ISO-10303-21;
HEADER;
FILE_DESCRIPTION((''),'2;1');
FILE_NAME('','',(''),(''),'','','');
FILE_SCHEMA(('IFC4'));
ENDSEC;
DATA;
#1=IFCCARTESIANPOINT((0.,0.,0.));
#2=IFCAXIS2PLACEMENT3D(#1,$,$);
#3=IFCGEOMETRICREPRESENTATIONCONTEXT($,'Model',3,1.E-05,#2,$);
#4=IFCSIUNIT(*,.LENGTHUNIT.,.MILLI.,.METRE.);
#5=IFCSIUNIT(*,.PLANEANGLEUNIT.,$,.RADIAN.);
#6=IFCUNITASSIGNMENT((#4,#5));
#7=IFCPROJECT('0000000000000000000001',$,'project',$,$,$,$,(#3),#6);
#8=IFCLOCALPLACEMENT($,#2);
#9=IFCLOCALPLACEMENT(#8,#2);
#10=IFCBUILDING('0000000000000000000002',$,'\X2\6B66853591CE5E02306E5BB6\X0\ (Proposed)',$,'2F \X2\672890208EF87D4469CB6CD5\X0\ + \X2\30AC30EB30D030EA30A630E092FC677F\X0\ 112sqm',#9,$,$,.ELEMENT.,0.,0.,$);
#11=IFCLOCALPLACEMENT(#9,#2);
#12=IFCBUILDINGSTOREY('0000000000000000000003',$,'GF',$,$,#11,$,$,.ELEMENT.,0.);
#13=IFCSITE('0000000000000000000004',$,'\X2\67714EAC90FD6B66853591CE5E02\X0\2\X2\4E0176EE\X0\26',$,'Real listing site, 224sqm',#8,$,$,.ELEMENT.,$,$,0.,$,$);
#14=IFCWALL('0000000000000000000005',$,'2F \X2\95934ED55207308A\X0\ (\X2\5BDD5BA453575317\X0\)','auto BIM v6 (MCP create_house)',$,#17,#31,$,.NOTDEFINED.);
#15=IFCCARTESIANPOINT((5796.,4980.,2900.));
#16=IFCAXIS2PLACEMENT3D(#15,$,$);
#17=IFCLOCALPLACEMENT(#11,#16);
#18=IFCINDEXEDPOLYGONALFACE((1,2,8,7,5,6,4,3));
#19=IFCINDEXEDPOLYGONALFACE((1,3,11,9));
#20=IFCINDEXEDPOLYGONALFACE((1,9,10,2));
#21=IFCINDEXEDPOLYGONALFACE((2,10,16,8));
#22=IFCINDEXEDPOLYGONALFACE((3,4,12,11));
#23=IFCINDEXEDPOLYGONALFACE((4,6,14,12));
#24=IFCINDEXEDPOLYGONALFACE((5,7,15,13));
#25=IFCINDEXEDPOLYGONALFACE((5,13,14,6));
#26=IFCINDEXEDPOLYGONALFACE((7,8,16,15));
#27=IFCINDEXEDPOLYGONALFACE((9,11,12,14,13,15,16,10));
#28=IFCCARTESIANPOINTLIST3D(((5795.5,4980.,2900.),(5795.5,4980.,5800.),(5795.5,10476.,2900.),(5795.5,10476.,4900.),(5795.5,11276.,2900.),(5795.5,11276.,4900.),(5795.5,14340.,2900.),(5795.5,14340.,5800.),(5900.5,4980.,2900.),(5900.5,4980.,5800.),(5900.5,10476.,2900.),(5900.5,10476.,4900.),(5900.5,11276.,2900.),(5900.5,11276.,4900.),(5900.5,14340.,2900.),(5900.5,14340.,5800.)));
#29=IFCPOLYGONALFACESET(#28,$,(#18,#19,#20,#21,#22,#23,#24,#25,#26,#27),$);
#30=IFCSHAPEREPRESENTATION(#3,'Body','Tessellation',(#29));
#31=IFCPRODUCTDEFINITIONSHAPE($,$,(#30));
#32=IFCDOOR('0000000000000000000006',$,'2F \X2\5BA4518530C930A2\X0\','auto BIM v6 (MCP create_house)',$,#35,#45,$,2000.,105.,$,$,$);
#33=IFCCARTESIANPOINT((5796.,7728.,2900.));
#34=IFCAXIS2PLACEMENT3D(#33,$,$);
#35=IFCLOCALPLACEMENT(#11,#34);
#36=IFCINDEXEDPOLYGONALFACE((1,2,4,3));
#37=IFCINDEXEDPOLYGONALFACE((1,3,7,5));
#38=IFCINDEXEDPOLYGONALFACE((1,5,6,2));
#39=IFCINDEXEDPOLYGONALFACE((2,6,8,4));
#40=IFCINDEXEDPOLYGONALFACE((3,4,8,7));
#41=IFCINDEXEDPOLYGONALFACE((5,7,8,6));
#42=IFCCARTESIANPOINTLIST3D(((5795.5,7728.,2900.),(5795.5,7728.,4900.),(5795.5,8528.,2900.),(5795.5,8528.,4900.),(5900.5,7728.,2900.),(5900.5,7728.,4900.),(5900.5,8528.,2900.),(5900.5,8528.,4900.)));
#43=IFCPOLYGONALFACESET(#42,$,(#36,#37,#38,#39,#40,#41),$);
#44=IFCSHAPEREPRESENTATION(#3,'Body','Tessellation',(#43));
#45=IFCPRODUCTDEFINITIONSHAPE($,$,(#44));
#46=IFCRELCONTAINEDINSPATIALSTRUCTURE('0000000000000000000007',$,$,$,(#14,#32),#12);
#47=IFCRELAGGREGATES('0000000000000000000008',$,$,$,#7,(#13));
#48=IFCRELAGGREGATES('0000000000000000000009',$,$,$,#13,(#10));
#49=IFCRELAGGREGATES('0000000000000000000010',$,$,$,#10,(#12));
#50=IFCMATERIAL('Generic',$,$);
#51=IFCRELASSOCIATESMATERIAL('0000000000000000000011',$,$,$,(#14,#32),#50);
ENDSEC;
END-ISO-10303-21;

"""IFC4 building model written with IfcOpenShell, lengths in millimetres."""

from ifc_helpers import new_model, si_unit, frame, frame_2d, origin, place, context, project, spatial, rectangle, extrude, material, element, fill, save


model = new_model("IFC4")

# Units and contexts
model_context = context("Model", 3, precision=1e-05, world=origin())
ifc_project = project(units=[si_unit("LENGTHUNIT", "METRE", prefix="MILLI"), si_unit("PLANEANGLEUNIT", "RADIAN")], contexts=[model_context])

# Site, building, storey
site_placement = place(None, origin())
site = spatial("IfcSite", under=ifc_project, at=site_placement, Name="東京都武蔵野市2丁目26", ObjectType="Real listing site, 224sqm", CompositionType="ELEMENT", RefElevation=0.0)
building_placement = place(site_placement, origin())
building = spatial("IfcBuilding", under=site, at=building_placement, Name="武蔵野市の家 (Proposed)", ObjectType="2F 木造軸組構法 + ガルバリウム鋼板 112sqm", CompositionType="ELEMENT", ElevationOfRefHeight=0.0, ElevationOfTerrain=0.0)
storey_placement = place(building_placement, origin())
storey = spatial("IfcBuildingStorey", under=building, at=storey_placement, Name="GF", CompositionType="ELEMENT", Elevation=0.0)

# Shared definitions
ifc_material = material(Name="Generic")

# Wall, opening, door
wall_1_placement = place(storey_placement, frame((5796.0, 4980.0, 2900.0)))
wall_1 = element("IfcWall", 1, at=wall_1_placement, inside=storey, material=ifc_material, Name="2F 間仕切り (寝室南北)", Description="auto BIM v6 (MCP create_house)", PredefinedType="NOTDEFINED", context=model_context, shape_type="SweptSolid", body=[
    extrude(rectangle(XDim=105.0, YDim=9360.0, at=frame_2d((52.0, 4680.0))), frame((5796.0, 4980.0, 2900.0)), (0.0, 0.0, 1.0), 2900.0),
])
opening_1_placement = place(storey_placement, frame((5796.0, 7728.0, 2900.0)))
opening_1 = element("IfcOpeningElement", 2, at=opening_1_placement, cuts=wall_1, PredefinedType="NOTDEFINED", context=model_context, shape_type="SweptSolid", body=[
    extrude(rectangle(XDim=105.0, YDim=800.0, at=frame_2d((52.0, 400.0))), frame((5796.0, 7728.0, 2900.0)), (0.0, 0.0, 1.0), 2000.0),
])
door_placement = place(storey_placement, frame((5796.0, 7728.0, 2900.0)))
door = element("IfcDoor", 3, at=door_placement, inside=storey, material=ifc_material, Name="2F 室内ドア", Description="auto BIM v6 (MCP create_house)", OverallHeight=2000.0, OverallWidth=105.0, context=model_context, shape_type="SweptSolid", body=[
    extrude(rectangle(XDim=105.0, YDim=800.0, at=frame_2d((52.0, 400.0))), frame((5796.0, 7728.0, 2900.0)), (0.0, 0.0, 1.0), 2000.0),
])
fill(opening_1, door)

save(model, "model.ifc")
